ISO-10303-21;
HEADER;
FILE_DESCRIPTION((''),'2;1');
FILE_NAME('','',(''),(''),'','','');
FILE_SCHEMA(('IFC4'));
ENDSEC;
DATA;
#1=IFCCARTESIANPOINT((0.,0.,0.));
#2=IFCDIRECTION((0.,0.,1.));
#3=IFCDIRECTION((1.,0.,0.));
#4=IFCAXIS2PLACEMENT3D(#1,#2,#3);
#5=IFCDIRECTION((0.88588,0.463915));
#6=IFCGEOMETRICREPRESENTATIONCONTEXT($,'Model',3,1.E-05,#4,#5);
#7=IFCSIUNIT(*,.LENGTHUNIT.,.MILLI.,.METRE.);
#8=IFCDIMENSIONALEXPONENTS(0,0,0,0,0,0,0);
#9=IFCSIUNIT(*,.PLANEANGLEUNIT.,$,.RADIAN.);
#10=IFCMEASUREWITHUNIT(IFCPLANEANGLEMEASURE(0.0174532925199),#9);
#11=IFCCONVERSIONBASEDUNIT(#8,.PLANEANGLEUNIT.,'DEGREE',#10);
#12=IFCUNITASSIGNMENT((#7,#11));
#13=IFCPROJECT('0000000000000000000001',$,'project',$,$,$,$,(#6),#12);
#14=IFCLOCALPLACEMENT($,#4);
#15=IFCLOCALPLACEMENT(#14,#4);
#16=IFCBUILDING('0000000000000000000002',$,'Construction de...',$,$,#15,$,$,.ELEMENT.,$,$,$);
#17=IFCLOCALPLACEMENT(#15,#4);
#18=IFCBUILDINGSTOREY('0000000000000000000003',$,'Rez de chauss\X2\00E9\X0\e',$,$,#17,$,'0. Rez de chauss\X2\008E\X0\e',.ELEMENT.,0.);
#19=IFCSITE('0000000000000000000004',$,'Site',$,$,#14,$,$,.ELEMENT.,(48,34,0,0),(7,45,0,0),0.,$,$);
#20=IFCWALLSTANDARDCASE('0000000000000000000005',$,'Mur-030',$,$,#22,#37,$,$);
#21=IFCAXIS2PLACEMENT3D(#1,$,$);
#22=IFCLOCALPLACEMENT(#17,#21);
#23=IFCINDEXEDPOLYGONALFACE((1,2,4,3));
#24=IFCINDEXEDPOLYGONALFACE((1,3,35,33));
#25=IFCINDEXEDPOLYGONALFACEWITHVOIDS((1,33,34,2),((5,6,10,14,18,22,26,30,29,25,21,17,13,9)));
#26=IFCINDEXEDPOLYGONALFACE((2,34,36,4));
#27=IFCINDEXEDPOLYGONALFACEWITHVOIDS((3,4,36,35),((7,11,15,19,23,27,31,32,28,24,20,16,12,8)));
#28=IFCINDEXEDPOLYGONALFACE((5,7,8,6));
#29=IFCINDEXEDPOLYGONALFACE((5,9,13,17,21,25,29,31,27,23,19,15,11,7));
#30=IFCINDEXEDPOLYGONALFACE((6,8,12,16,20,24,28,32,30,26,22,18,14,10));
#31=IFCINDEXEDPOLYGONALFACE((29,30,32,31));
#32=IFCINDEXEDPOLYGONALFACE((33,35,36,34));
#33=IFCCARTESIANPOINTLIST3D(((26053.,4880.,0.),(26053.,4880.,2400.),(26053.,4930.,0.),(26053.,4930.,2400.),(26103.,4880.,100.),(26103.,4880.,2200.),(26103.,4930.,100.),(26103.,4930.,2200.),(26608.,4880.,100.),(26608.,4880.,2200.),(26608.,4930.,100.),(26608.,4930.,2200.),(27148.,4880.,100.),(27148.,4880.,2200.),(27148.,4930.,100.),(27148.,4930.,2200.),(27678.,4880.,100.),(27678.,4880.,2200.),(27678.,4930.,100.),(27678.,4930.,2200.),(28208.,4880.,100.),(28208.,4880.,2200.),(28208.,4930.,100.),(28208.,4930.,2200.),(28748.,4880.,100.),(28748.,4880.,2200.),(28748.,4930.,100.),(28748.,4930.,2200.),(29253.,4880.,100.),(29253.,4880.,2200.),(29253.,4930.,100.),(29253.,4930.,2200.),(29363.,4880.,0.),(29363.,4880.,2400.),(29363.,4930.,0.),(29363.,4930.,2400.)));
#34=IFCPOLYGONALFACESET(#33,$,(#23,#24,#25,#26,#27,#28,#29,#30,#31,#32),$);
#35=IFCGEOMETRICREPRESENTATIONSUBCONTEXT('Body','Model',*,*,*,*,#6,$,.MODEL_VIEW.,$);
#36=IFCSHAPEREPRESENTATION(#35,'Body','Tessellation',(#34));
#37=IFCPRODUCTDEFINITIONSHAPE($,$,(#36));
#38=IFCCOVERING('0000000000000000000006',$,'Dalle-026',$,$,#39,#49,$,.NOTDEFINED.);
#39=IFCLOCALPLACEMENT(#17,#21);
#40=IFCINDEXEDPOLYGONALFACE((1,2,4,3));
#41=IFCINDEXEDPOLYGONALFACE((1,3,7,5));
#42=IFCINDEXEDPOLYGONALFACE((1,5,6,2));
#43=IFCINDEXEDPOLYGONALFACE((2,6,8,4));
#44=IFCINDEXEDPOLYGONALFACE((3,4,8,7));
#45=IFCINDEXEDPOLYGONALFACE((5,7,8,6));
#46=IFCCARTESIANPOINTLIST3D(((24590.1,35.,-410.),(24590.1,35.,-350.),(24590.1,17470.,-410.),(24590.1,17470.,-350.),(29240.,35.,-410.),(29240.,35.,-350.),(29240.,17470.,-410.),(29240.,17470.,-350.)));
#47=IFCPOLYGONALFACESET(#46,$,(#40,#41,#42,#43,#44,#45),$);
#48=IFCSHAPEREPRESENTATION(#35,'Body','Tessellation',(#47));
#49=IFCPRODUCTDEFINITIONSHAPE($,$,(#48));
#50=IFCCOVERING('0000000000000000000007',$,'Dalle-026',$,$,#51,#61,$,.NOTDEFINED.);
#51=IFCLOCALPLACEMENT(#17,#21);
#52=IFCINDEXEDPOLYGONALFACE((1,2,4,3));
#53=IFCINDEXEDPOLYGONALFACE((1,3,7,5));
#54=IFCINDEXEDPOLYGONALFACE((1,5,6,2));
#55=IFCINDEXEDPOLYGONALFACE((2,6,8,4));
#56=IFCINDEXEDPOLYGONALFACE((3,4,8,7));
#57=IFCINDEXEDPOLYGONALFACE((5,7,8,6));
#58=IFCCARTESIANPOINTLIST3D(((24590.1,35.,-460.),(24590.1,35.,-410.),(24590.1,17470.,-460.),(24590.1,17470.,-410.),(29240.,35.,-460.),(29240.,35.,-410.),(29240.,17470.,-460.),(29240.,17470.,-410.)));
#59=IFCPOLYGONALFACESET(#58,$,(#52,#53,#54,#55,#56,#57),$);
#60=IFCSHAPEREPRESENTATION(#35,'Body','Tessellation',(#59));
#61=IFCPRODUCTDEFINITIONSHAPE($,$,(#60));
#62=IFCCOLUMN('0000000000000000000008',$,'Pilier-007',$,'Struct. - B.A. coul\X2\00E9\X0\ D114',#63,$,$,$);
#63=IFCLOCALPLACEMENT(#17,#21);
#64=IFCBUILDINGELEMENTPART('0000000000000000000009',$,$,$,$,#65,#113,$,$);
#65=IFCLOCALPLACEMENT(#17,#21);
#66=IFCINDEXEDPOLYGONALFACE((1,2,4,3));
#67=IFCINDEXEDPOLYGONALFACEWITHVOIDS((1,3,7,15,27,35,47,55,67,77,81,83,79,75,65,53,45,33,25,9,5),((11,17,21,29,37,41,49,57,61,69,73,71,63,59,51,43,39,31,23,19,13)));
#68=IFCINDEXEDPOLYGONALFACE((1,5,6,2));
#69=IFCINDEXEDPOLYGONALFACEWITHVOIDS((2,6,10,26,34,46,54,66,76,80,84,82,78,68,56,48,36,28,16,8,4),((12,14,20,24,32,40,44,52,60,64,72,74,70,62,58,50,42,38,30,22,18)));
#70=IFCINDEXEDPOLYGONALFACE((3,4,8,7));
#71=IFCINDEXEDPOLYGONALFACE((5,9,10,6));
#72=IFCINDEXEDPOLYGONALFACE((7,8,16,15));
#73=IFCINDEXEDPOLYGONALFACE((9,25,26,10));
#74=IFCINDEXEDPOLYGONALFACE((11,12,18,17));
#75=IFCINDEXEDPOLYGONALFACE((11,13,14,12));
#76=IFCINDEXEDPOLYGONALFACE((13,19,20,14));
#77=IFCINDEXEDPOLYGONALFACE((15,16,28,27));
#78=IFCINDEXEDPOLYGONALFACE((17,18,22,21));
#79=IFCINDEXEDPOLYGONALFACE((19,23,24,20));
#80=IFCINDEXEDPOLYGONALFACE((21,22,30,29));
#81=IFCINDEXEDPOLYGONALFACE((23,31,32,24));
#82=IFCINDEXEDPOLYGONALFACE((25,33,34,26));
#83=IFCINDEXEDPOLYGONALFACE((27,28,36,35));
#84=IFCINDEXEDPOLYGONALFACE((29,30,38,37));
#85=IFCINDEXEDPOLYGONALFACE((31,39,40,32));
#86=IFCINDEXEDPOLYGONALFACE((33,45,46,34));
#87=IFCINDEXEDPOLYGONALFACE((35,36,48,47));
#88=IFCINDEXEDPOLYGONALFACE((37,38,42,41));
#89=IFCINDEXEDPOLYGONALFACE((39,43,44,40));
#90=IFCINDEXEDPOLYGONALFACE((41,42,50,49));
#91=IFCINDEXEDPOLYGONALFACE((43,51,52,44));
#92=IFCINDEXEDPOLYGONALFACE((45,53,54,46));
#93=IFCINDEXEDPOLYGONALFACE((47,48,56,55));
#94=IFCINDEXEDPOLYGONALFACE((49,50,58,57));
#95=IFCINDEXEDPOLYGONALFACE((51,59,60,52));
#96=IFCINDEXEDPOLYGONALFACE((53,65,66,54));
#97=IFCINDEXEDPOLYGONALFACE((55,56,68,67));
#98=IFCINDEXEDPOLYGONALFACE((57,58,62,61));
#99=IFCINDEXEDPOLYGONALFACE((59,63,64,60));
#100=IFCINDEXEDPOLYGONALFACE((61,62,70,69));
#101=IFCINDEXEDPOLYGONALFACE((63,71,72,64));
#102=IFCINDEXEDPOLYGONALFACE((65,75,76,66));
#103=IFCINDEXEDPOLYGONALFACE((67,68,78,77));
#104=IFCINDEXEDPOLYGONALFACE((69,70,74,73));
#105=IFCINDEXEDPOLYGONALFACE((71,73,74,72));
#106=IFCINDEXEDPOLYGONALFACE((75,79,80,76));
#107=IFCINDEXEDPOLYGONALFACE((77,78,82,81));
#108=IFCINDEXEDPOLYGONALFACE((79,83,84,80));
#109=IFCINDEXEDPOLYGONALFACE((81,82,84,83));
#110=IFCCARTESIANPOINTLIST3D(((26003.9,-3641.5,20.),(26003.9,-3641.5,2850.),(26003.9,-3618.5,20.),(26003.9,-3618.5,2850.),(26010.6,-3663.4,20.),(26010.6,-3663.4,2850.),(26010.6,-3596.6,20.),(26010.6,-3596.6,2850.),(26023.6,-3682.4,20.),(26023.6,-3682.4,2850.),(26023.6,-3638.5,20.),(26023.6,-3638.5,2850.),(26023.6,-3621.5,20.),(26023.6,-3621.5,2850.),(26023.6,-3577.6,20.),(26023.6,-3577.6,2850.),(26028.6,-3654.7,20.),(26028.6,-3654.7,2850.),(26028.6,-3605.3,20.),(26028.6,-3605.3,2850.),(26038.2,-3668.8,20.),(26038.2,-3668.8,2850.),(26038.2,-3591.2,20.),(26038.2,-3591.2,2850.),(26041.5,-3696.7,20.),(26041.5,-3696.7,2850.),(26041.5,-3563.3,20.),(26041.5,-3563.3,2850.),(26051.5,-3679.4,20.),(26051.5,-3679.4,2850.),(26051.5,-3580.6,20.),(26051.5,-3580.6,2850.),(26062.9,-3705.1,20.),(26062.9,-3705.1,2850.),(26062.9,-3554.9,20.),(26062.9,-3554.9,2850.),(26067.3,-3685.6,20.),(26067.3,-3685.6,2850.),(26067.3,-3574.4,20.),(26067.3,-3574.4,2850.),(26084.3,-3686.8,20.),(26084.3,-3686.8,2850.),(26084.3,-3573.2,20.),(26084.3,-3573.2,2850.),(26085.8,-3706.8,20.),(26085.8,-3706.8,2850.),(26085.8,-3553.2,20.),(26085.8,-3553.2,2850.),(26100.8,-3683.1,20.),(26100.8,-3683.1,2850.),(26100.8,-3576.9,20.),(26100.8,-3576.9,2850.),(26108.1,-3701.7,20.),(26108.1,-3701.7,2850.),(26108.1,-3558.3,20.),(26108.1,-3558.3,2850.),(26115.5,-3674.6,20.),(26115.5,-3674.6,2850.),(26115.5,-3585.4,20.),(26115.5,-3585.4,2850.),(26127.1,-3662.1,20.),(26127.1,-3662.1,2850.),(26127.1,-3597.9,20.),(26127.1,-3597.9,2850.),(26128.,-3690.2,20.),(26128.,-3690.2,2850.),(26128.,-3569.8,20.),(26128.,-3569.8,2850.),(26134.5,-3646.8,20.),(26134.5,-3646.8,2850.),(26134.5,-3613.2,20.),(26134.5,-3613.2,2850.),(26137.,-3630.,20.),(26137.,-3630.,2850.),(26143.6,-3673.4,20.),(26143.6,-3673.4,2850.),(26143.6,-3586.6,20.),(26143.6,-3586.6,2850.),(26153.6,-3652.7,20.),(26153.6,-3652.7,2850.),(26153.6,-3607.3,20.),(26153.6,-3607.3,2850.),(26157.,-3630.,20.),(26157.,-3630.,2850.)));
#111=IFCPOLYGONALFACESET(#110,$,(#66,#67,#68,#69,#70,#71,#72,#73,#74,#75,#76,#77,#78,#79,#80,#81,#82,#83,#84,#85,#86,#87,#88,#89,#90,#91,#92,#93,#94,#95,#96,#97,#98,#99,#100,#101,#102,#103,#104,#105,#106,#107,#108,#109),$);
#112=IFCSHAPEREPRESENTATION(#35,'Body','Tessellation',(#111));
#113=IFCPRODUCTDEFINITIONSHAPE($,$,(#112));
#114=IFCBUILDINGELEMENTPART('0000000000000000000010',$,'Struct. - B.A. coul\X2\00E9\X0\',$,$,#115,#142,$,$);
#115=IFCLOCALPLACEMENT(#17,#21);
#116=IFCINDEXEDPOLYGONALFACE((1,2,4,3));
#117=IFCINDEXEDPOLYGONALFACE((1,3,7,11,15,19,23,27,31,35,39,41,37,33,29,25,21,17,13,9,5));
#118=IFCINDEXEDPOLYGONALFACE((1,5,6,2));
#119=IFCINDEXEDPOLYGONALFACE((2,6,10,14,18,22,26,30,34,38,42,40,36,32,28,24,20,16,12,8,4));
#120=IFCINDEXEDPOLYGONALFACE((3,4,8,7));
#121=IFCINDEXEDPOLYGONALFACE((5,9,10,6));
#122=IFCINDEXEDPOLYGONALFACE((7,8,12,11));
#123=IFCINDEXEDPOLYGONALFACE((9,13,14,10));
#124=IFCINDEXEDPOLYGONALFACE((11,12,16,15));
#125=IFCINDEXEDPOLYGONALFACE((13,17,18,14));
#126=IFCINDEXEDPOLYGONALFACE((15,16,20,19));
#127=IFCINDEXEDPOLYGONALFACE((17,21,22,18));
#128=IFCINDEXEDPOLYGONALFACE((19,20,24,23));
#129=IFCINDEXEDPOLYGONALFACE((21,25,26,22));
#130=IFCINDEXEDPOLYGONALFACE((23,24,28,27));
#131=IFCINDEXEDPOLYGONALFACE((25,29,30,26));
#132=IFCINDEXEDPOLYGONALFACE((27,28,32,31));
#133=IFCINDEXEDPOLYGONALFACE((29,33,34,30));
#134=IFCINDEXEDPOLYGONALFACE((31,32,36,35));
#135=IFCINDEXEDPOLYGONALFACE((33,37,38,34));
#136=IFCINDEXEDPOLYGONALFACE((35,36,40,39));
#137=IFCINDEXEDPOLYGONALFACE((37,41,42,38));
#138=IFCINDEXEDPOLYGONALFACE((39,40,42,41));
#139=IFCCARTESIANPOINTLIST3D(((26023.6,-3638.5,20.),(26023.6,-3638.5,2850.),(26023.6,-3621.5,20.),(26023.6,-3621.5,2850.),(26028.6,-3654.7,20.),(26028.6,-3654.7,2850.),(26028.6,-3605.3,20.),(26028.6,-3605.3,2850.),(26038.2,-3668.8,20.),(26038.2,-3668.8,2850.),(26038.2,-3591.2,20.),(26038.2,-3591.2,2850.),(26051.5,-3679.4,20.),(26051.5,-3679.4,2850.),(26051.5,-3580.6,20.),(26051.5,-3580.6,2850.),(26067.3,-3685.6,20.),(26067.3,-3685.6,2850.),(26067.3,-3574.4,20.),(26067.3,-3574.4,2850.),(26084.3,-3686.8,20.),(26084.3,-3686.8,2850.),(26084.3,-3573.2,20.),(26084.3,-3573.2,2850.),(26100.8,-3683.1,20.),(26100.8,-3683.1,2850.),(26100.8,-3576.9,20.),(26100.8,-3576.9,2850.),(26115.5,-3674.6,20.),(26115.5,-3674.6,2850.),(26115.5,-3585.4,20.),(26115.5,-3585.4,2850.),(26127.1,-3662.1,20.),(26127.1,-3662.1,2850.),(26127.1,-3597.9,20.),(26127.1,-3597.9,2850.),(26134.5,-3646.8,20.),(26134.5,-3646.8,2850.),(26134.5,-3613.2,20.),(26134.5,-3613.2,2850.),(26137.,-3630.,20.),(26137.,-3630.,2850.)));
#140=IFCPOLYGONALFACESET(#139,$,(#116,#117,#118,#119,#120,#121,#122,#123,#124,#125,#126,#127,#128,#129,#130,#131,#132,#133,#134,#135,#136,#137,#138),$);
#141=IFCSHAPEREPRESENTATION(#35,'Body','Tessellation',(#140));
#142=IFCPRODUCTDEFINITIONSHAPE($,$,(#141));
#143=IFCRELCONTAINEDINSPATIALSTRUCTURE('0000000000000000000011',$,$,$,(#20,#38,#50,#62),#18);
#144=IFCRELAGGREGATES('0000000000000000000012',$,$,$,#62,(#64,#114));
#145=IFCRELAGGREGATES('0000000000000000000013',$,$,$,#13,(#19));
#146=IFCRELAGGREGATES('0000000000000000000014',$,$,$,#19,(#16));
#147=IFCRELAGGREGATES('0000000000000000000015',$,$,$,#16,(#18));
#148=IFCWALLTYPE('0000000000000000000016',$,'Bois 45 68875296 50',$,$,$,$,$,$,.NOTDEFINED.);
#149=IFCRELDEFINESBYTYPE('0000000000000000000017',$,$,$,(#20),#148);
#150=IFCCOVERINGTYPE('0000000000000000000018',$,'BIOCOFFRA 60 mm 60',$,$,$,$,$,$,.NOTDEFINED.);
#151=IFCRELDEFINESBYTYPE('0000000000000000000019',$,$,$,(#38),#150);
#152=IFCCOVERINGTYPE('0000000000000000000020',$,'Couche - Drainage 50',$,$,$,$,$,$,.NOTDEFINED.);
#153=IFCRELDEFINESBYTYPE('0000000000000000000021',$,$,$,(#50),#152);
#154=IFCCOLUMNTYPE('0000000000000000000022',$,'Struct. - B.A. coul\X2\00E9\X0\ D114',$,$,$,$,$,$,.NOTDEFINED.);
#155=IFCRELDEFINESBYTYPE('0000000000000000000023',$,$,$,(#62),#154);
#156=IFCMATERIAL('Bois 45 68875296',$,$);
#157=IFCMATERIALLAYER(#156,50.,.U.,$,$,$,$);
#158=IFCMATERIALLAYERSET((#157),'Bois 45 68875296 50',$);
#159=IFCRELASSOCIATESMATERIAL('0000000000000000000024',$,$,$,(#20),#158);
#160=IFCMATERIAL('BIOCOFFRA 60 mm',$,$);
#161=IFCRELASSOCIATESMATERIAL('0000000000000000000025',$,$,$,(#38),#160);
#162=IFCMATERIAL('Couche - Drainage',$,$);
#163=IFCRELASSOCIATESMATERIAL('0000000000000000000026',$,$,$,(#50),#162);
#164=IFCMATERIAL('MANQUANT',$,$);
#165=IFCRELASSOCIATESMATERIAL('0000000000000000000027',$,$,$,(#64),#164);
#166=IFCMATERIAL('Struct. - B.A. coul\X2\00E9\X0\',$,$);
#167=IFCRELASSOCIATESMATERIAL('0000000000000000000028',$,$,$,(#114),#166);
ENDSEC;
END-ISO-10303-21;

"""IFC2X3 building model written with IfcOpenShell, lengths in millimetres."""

from ifc_helpers import new_model, entity, si_unit, converted_unit, direction, frame, origin_with_axes, origin_2d_with_axis, place, context, subcontext, project, spatial, polyline, rectangle, circle, hollow_circle, outline, extrude, material, layer, layer_set, layer_usage, type_object, element, aggregate, save


model = new_model("IFC2X3")

# Units and contexts
model_context = context("Model", 3, precision=1e-05, world=origin_with_axes(), true_north=direction((0.88588, 0.463915)))
body_context = subcontext(model_context, "Body", "Model", "MODEL_VIEW")
ifc_project = project(units=[si_unit("LENGTHUNIT", "METRE", prefix="MILLI"), converted_unit("PLANEANGLEUNIT", "DEGREE", entity("IfcPlaneAngleMeasure", 0.0174532925199), si_unit("PLANEANGLEUNIT", "RADIAN"), dimensions=[0, 0, 0, 0, 0, 0, 0])], contexts=[model_context])

# Site, building, storey
site_placement = place(None, origin_with_axes())
site = spatial("IfcSite", under=ifc_project, at=site_placement, Name="Site", CompositionType="ELEMENT", RefLatitude=(48, 34, 0, 0), RefLongitude=(7, 45, 0, 0), RefElevation=0.0)
building_placement = place(site_placement, origin_with_axes())
building = spatial("IfcBuilding", under=site, at=building_placement, Name="Construction de...", CompositionType="ELEMENT")
storey_placement = place(building_placement, origin_with_axes())
storey = spatial("IfcBuildingStorey", under=building, at=storey_placement, Name="Rez de chaussée", LongName="0. Rez de chauss\u008ee", CompositionType="ELEMENT", Elevation=0.0)

# Shared definitions
ifc_material_1 = material(Name="Struct. - B.A. coulé")

# Wall, openings
ifc_material_2 = material(Name="Bois 45 68875296")
ifc_layer_1 = layer(ifc_material_2, 50.0, ventilated="UNKNOWN")
ifc_layer_set_1 = layer_set([ifc_layer_1], Name="Bois 45 68875296 50")
ifc_layer_usage_1 = layer_usage(ifc_layer_set_1, "AXIS2", "NEGATIVE", 25.0)
wall_type_1 = type_object("IfcWallType", Name="Bois 45 68875296 50", PredefinedType="NOTDEFINED")
wall_1_placement = place(storey_placement, frame((26053.0, 4905.0, 0.0), z_axis=(0.0, 0.0, 1.0), x_axis=(1.0, 0.0, 0.0)))
wall_1 = element("IfcWallStandardCase", 1, at=wall_1_placement, inside=storey, type_object=wall_type_1, material=ifc_layer_usage_1, Name="Mur-030", context=body_context, shape_type="SweptSolid", body=[
    extrude(outline(polyline([(0.0, -25.0), (3310.0, -25.0), (3310.0, 25.0), (0.0, 25.0), (0.0, -25.0)])), origin_with_axes(), (0.0, 0.0, 1.0), 2400.0),
])
opening_1_placement = place(wall_1_placement, frame((2947.5, 0.0, 100.0), z_axis=(0.0, 0.0, 1.0), x_axis=(1.0, 0.0, 0.0)))
element("IfcOpeningElement", 2, at=opening_1_placement, cuts=wall_1, context=body_context, shape_type="SweptSolid", body=[
    extrude(rectangle(XDim=505.0, YDim=2100.0, at=origin_2d_with_axis()), frame((0.0, 50.0, 1050.0), z_axis=(0.0, 1.0, 0.0), x_axis=(1.0, 0.0, 0.0)), (0.0, 0.0, -1.0), 150.0),
])
opening_2_placement = place(wall_1_placement, frame((2425.0, 0.0, 100.0), z_axis=(0.0, 0.0, 1.0), x_axis=(1.0, 0.0, 0.0)))
element("IfcOpeningElement", 3, at=opening_2_placement, cuts=wall_1, context=body_context, shape_type="SweptSolid", body=[
    extrude(rectangle(XDim=540.0, YDim=2100.0, at=origin_2d_with_axis()), frame((0.0, 50.0, 1050.0), z_axis=(0.0, -1.0, 0.0), x_axis=(-1.0, 0.0, 0.0)), (0.0, 0.0, 1.0), 150.0),
])
opening_3_placement = place(wall_1_placement, frame((1890.0, 0.0, 100.0), z_axis=(0.0, 0.0, 1.0), x_axis=(1.0, 0.0, 0.0)))
element("IfcOpeningElement", 4, at=opening_3_placement, cuts=wall_1, context=body_context, shape_type="SweptSolid", body=[
    extrude(rectangle(XDim=530.0, YDim=2100.0, at=origin_2d_with_axis()), frame((0.0, 50.0, 1050.0), z_axis=(0.0, 1.0, 0.0), x_axis=(1.0, 0.0, 0.0)), (0.0, 0.0, -1.0), 150.0),
])
opening_4_placement = place(wall_1_placement, frame((1360.0, 0.0, 100.0), z_axis=(0.0, 0.0, 1.0), x_axis=(1.0, 0.0, 0.0)))
element("IfcOpeningElement", 5, at=opening_4_placement, cuts=wall_1, context=body_context, shape_type="SweptSolid", body=[
    extrude(rectangle(XDim=530.0, YDim=2100.0, at=origin_2d_with_axis()), frame((0.0, 50.0, 1050.0), z_axis=(0.0, -1.0, 0.0), x_axis=(-1.0, 0.0, 0.0)), (0.0, 0.0, 1.0), 150.0),
])
opening_5_placement = place(wall_1_placement, frame((825.0, 0.0, 100.0), z_axis=(0.0, 0.0, 1.0), x_axis=(1.0, 0.0, 0.0)))
element("IfcOpeningElement", 6, at=opening_5_placement, cuts=wall_1, context=body_context, shape_type="SweptSolid", body=[
    extrude(rectangle(XDim=540.0, YDim=2100.0, at=origin_2d_with_axis()), frame((0.0, 50.0, 1050.0), z_axis=(0.0, 1.0, 0.0), x_axis=(1.0, 0.0, 0.0)), (0.0, 0.0, -1.0), 150.0),
])
opening_6_placement = place(wall_1_placement, frame((302.5, 0.0, 100.0), z_axis=(0.0, 0.0, 1.0), x_axis=(1.0, 0.0, 0.0)))
element("IfcOpeningElement", 7, at=opening_6_placement, cuts=wall_1, context=body_context, shape_type="SweptSolid", body=[
    extrude(rectangle(XDim=505.0, YDim=2100.0, at=origin_2d_with_axis()), frame((0.0, 50.0, 1050.0), z_axis=(0.0, -1.0, 0.0), x_axis=(-1.0, 0.0, 0.0)), (0.0, 0.0, 1.0), 150.0),
])

# Coverings
ifc_material_3 = material(Name="BIOCOFFRA 60 mm")
covering_type_1 = type_object("IfcCoveringType", Name="BIOCOFFRA 60 mm 60", PredefinedType="NOTDEFINED")
covering_1_placement = place(storey_placement, frame((24590.1, 35.0, -350.0), z_axis=(0.0, 0.0, 1.0), x_axis=(1.0, 0.0, 0.0)))
element("IfcCovering", 8, at=covering_1_placement, inside=storey, type_object=covering_type_1, material=ifc_material_3, Name="Dalle-026", PredefinedType="NOTDEFINED", context=body_context, shape_type="SweptSolid", body=[
    extrude(outline(polyline([(0.0, 0.0), (4649.9, 0.0), (4649.9, 17435.0), (0.0, 17435.0), (0.0, 0.0)])), frame((0.0, 0.0, -60.0), z_axis=(0.0, 0.0, 1.0), x_axis=(1.0, 0.0, 0.0)), (0.0, 0.0, 1.0), 60.0),
])
ifc_material_4 = material(Name="Couche - Drainage")
covering_type_2 = type_object("IfcCoveringType", Name="Couche - Drainage 50", PredefinedType="NOTDEFINED")
covering_2_placement = place(storey_placement, frame((24590.1, 35.0, -410.0), z_axis=(0.0, 0.0, 1.0), x_axis=(1.0, 0.0, 0.0)))
element("IfcCovering", 9, at=covering_2_placement, inside=storey, type_object=covering_type_2, material=ifc_material_4, Name="Dalle-026", PredefinedType="NOTDEFINED", context=body_context, shape_type="SweptSolid", body=[
    extrude(outline(polyline([(0.0, 0.0), (4649.9, 0.0), (4649.9, 17435.0), (0.0, 17435.0), (0.0, 0.0)])), frame((0.0, 0.0, -50.0), z_axis=(0.0, 0.0, 1.0), x_axis=(1.0, 0.0, 0.0)), (0.0, 0.0, 1.0), 50.0),
])

# Column, building element parts
column_type = type_object("IfcColumnType", Name="Struct. - B.A. coulé D114", PredefinedType="NOTDEFINED")
column_placement = place(storey_placement, frame((26080.0, -3630.0, 20.0), z_axis=(0.0, 0.0, 1.0), x_axis=(1.0, 0.0, 0.0)))
column = element("IfcColumn", 10, at=column_placement, inside=storey, type_object=column_type, Name="Pilier-007", ObjectType="Struct. - B.A. coulé D114")
ifc_material_5 = material(Name="MANQUANT")
building_element_part_1_placement = place(column_placement, origin_with_axes())
building_element_part_1 = element("IfcBuildingElementPart", 11, at=building_element_part_1_placement, material=ifc_material_5, context=body_context, shape_type="SweptSolid", body=[
    extrude(hollow_circle(Radius=77.0, WallThickness=20.0, at=origin_2d_with_axis()), origin_with_axes(), (0.0, 0.0, 1.0), 2830.0),
])
building_element_part_2_placement = place(column_placement, origin_with_axes())
building_element_part_2 = element("IfcBuildingElementPart", 12, at=building_element_part_2_placement, material=ifc_material_1, Name="Struct. - B.A. coulé", context=body_context, shape_type="SweptSolid", body=[
    extrude(circle(Radius=57.0, at=origin_2d_with_axis()), origin_with_axes(), (0.0, 0.0, 1.0), 2830.0),
])
aggregate(column, [building_element_part_1, building_element_part_2])

save(model, "model.ifc")
